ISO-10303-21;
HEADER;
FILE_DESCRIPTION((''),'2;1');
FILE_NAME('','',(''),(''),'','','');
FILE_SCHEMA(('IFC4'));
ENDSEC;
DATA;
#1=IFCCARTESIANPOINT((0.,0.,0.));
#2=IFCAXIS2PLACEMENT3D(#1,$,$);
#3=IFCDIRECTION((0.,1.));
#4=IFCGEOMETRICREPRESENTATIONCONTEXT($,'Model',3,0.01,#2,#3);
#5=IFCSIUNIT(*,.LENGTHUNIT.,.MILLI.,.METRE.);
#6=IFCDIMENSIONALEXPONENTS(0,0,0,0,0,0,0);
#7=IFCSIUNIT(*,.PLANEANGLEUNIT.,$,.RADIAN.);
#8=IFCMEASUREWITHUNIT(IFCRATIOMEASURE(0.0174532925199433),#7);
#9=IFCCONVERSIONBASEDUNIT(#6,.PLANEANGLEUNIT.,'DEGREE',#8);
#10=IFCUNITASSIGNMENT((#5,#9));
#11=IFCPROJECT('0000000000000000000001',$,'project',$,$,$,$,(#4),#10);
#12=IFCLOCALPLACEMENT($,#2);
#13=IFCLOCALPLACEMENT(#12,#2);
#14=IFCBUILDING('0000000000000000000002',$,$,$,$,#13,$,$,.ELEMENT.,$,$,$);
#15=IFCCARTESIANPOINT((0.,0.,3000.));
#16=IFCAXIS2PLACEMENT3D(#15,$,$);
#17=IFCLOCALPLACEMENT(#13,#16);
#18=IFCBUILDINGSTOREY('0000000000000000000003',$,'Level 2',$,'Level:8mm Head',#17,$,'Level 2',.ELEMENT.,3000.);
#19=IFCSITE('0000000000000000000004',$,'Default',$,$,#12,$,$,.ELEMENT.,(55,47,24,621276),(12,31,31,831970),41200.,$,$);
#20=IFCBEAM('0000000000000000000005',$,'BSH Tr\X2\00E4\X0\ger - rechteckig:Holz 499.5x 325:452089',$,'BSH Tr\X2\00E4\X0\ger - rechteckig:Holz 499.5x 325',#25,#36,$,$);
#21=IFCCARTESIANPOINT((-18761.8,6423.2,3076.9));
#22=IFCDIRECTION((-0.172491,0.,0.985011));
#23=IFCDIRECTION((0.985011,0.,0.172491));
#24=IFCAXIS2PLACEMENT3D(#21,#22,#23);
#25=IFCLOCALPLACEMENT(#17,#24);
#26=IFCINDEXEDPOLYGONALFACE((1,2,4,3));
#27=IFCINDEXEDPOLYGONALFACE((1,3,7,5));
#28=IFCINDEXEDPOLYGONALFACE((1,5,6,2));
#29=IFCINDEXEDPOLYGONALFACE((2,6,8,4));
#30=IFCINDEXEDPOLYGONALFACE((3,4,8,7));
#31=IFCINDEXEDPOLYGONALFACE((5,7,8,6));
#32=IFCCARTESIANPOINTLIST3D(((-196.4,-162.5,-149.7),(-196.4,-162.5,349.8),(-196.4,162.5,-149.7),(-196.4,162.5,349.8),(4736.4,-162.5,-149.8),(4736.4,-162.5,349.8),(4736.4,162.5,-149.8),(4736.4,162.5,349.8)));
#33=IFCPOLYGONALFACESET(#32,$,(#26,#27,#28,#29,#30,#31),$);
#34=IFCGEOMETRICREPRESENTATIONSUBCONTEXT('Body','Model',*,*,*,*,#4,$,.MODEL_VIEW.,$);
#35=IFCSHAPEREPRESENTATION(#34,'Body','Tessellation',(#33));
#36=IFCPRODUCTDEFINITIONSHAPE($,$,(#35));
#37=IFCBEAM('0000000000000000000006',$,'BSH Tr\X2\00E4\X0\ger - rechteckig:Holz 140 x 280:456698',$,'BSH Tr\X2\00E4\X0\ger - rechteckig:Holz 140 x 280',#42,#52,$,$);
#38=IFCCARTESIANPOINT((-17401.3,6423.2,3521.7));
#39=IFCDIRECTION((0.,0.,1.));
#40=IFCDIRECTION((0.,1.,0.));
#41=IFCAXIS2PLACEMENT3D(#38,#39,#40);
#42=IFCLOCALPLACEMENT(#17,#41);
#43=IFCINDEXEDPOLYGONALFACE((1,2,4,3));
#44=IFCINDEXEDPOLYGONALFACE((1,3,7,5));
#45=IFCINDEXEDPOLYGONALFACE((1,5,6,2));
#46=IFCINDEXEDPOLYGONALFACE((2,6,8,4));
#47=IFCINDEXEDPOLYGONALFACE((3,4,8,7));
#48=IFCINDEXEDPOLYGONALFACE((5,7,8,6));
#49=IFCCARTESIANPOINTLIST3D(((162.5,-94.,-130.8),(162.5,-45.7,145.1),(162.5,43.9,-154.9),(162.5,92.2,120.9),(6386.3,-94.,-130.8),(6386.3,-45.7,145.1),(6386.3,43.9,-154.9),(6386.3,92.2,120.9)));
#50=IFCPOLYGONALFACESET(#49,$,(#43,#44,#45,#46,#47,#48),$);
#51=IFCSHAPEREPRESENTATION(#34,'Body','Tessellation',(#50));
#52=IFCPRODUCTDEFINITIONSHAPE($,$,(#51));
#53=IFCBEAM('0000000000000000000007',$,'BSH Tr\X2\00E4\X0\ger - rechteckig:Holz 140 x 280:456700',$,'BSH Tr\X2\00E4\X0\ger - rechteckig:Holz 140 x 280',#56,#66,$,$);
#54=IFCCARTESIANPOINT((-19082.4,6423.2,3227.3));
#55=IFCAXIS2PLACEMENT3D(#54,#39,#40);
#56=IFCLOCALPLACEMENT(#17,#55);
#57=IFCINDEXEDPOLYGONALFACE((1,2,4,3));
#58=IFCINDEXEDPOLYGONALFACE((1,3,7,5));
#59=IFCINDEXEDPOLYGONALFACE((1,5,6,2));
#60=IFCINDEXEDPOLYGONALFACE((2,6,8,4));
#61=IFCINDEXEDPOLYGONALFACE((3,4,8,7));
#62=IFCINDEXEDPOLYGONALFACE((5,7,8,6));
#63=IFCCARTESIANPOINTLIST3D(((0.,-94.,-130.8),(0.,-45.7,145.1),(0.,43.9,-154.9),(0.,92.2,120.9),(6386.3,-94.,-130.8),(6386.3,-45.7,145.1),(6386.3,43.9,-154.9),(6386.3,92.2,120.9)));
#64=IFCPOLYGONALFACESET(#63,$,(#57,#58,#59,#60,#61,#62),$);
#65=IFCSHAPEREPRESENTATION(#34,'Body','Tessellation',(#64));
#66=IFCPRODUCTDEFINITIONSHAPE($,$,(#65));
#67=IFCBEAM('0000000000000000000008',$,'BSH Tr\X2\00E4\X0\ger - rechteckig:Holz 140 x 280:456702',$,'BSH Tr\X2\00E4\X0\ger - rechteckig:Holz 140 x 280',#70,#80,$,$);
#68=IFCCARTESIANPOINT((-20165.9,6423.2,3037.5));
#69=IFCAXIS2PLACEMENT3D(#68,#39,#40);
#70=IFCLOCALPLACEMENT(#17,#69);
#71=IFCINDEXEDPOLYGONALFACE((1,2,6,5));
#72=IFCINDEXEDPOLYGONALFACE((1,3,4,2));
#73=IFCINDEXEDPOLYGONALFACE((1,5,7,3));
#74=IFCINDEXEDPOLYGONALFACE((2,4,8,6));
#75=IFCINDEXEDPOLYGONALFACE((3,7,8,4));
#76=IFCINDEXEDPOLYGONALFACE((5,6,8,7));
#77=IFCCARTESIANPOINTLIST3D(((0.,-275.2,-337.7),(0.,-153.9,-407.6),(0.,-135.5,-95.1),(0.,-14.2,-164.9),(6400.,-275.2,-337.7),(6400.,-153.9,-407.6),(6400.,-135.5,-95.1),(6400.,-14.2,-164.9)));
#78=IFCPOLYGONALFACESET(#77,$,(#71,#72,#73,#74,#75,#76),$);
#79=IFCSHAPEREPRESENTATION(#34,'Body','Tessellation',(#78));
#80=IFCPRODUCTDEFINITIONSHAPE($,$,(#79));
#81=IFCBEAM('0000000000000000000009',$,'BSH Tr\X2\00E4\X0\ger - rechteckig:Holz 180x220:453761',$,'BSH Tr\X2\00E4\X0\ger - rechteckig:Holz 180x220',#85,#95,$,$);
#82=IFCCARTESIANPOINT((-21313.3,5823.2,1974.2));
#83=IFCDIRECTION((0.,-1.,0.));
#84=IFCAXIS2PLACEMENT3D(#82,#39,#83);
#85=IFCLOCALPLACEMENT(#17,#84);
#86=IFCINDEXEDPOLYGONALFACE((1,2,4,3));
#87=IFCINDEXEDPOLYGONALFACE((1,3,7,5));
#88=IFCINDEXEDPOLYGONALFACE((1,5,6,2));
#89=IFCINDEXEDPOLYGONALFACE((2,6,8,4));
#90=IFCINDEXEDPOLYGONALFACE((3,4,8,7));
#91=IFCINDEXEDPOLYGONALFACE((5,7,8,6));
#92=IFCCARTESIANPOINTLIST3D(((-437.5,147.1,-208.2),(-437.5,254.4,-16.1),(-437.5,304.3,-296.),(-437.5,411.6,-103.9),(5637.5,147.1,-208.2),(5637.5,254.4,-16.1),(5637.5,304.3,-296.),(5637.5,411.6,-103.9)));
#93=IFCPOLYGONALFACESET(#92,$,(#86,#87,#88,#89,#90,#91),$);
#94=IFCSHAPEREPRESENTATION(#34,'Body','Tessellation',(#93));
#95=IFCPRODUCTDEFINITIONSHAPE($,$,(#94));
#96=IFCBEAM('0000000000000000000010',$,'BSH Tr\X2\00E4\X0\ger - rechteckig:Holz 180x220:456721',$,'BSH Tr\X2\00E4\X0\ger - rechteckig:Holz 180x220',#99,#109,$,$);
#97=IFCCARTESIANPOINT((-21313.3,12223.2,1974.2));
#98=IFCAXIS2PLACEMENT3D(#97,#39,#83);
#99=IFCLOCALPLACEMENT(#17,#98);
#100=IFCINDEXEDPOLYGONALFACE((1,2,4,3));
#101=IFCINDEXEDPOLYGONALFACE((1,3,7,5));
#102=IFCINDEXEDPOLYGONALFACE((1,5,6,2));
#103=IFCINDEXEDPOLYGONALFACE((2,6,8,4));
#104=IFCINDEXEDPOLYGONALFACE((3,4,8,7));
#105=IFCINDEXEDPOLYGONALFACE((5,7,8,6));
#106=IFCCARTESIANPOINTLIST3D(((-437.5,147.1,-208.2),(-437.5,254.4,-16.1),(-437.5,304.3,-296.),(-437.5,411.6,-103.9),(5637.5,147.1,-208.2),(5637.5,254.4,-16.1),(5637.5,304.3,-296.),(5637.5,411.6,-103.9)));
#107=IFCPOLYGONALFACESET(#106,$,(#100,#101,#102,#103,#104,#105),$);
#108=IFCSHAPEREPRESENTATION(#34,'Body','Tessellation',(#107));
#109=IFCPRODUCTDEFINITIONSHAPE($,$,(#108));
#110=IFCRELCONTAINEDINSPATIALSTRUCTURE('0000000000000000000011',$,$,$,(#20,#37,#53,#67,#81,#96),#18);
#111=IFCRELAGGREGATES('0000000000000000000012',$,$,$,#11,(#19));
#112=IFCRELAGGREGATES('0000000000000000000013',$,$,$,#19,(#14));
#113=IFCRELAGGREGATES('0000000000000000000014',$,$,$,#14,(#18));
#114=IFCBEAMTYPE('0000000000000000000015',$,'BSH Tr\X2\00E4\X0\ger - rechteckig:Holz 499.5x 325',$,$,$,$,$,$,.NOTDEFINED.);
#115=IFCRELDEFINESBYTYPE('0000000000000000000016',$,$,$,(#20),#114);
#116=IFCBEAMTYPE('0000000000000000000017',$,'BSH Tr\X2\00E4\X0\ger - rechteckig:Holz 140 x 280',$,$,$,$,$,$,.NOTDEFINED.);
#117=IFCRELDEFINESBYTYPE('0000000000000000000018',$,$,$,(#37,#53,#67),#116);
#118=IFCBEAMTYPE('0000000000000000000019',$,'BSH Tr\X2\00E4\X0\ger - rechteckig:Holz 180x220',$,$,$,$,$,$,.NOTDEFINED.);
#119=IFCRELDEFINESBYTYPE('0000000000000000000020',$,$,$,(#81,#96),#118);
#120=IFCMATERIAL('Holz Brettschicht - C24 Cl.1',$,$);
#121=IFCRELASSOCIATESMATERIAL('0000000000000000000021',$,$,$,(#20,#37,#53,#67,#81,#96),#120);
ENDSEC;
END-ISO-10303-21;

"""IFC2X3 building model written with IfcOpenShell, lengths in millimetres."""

from ifc_helpers import new_model, entity, si_unit, converted_unit, direction, frame, frame_2d, origin, origin_2d_with_axis, place, context, subcontext, project, spatial, rectangle, extrude, material, type_object, element, save


model = new_model("IFC2X3")

# Units and contexts
model_context = context("Model", 3, precision=0.01, world=origin(), true_north=direction((0.0, 1.0)))
body_context = subcontext(model_context, "Body", "Model", "MODEL_VIEW")
ifc_project = project(units=[si_unit("LENGTHUNIT", "METRE", prefix="MILLI"), converted_unit("PLANEANGLEUNIT", "DEGREE", entity("IfcRatioMeasure", 0.0174532925199433), si_unit("PLANEANGLEUNIT", "RADIAN"), dimensions=[0, 0, 0, 0, 0, 0, 0])], contexts=[model_context])

# Site, building, storey
site_placement = place(None, origin())
site = spatial("IfcSite", under=ifc_project, at=site_placement, Name="Default", CompositionType="ELEMENT", RefLatitude=(55, 47, 24, 621276), RefLongitude=(12, 31, 31, 831970), RefElevation=41200.0)
building_placement = place(site_placement, origin())
building = spatial("IfcBuilding", under=site, at=building_placement, CompositionType="ELEMENT")
storey_placement = place(building_placement, frame((0.0, 0.0, 3000.0)))
storey = spatial("IfcBuildingStorey", under=building, at=storey_placement, Name="Level 2", ObjectType="Level:8mm Head", LongName="Level 2", CompositionType="ELEMENT", Elevation=3000.0)

# Beams
ifc_material = material(Name="Holz Brettschicht - C24 Cl.1")
beam_type_1 = type_object("IfcBeamType", Name="BSH Träger - rechteckig:Holz 499.5x 325", PredefinedType="NOTDEFINED")
beam_1_placement = place(storey_placement, frame((-18761.8, 6423.2, 3076.9), z_axis=(-0.172491, 0.0, 0.985011), x_axis=(0.985011, 0.0, 0.172491)))
element("IfcBeam", 1, at=beam_1_placement, inside=storey, type_object=beam_type_1, material=ifc_material, Name="BSH Träger - rechteckig:Holz 499.5x 325:452089", ObjectType="BSH Träger - rechteckig:Holz 499.5x 325", context=body_context, shape_type="SweptSolid", body=[
    extrude(rectangle(XDim=499.5, YDim=325.0, at=frame_2d((0.0, 0.0), x_axis=(1.0, 0.0))), frame((-196.4, 0.0, 100.0), z_axis=(1.0, 0.0, 0.0), x_axis=(0.0, 0.0, -1.0)), (0.0, 0.0, 1.0), 4932.8),
])
beam_type_2 = type_object("IfcBeamType", Name="BSH Träger - rechteckig:Holz 140 x 280", PredefinedType="NOTDEFINED")
beam_2_placement = place(storey_placement, frame((-17401.3, 6423.2, 3521.7), z_axis=(0.0, 0.0, 1.0), x_axis=(0.0, 1.0, 0.0)))
element("IfcBeam", 2, at=beam_2_placement, inside=storey, type_object=beam_type_2, material=ifc_material, Name="BSH Träger - rechteckig:Holz 140 x 280:456698", ObjectType="BSH Träger - rechteckig:Holz 140 x 280", context=body_context, shape_type="SweptSolid", body=[
    extrude(rectangle(XDim=280.0, YDim=140.0, at=frame_2d((0.0, 0.0), x_axis=(1.0, 0.0))), frame((162.5, -0.9, -4.9), z_axis=(1.0, 0.0, 0.0), x_axis=(0.0, 0.172491, 0.985011)), (0.0, 0.0, 1.0), 6223.8),
])
beam_3_placement = place(storey_placement, frame((-19082.4, 6423.2, 3227.3), z_axis=(0.0, 0.0, 1.0), x_axis=(0.0, 1.0, 0.0)))
element("IfcBeam", 3, at=beam_3_placement, inside=storey, type_object=beam_type_2, material=ifc_material, Name="BSH Träger - rechteckig:Holz 140 x 280:456700", ObjectType="BSH Träger - rechteckig:Holz 140 x 280", context=body_context, shape_type="SweptSolid", body=[
    extrude(rectangle(XDim=280.0, YDim=140.0, at=origin_2d_with_axis()), frame((0.0, -0.9, -4.9), z_axis=(1.0, 0.0, 0.0), x_axis=(0.0, 0.172491, 0.985011)), (0.0, 0.0, 1.0), 6386.3),
])
beam_4_placement = place(storey_placement, frame((-20165.9, 6423.2, 3037.5), z_axis=(0.0, 0.0, 1.0), x_axis=(0.0, 1.0, 0.0)))
element("IfcBeam", 4, at=beam_4_placement, inside=storey, type_object=beam_type_2, material=ifc_material, Name="BSH Träger - rechteckig:Holz 140 x 280:456702", ObjectType="BSH Träger - rechteckig:Holz 140 x 280", context=body_context, shape_type="SweptSolid", body=[
    extrude(rectangle(XDim=280.0, YDim=140.0, at=origin_2d_with_axis()), frame((0.0, -144.7, -251.3), z_axis=(1.0, 0.0, 0.0), x_axis=(0.0, 0.498982, 0.866612)), (0.0, 0.0, 1.0), 6400.0),
])
beam_type_3 = type_object("IfcBeamType", Name="BSH Träger - rechteckig:Holz 180x220", PredefinedType="NOTDEFINED")
beam_5_placement = place(storey_placement, frame((-21313.3, 5823.2, 1974.2), z_axis=(0.0, 0.0, 1.0), x_axis=(0.0, -1.0, 0.0)))
element("IfcBeam", 5, at=beam_5_placement, inside=storey, type_object=beam_type_3, material=ifc_material, Name="BSH Träger - rechteckig:Holz 180x220:453761", ObjectType="BSH Träger - rechteckig:Holz 180x220", context=body_context, shape_type="SweptSolid", body=[
    extrude(rectangle(XDim=220.0, YDim=180.0, at=frame_2d((0.0, 0.0), x_axis=(1.0, 0.0))), frame((-437.5, 279.4, -156.1), z_axis=(1.0, 0.0, 0.0), x_axis=(0.0, 0.4877, 0.873011)), (0.0, 0.0, 1.0), 6075.0),
])
beam_6_placement = place(storey_placement, frame((-21313.3, 12223.2, 1974.2), z_axis=(0.0, 0.0, 1.0), x_axis=(0.0, -1.0, 0.0)))
element("IfcBeam", 6, at=beam_6_placement, inside=storey, type_object=beam_type_3, material=ifc_material, Name="BSH Träger - rechteckig:Holz 180x220:456721", ObjectType="BSH Träger - rechteckig:Holz 180x220", context=body_context, shape_type="SweptSolid", body=[
    extrude(rectangle(XDim=220.0, YDim=180.0, at=frame_2d((0.0, 0.0), x_axis=(1.0, 0.0))), frame((-437.5, 279.4, -156.1), z_axis=(1.0, 0.0, 0.0), x_axis=(0.0, 0.4877, 0.873011)), (0.0, 0.0, 1.0), 6075.0),
])

save(model, "model.ifc")
